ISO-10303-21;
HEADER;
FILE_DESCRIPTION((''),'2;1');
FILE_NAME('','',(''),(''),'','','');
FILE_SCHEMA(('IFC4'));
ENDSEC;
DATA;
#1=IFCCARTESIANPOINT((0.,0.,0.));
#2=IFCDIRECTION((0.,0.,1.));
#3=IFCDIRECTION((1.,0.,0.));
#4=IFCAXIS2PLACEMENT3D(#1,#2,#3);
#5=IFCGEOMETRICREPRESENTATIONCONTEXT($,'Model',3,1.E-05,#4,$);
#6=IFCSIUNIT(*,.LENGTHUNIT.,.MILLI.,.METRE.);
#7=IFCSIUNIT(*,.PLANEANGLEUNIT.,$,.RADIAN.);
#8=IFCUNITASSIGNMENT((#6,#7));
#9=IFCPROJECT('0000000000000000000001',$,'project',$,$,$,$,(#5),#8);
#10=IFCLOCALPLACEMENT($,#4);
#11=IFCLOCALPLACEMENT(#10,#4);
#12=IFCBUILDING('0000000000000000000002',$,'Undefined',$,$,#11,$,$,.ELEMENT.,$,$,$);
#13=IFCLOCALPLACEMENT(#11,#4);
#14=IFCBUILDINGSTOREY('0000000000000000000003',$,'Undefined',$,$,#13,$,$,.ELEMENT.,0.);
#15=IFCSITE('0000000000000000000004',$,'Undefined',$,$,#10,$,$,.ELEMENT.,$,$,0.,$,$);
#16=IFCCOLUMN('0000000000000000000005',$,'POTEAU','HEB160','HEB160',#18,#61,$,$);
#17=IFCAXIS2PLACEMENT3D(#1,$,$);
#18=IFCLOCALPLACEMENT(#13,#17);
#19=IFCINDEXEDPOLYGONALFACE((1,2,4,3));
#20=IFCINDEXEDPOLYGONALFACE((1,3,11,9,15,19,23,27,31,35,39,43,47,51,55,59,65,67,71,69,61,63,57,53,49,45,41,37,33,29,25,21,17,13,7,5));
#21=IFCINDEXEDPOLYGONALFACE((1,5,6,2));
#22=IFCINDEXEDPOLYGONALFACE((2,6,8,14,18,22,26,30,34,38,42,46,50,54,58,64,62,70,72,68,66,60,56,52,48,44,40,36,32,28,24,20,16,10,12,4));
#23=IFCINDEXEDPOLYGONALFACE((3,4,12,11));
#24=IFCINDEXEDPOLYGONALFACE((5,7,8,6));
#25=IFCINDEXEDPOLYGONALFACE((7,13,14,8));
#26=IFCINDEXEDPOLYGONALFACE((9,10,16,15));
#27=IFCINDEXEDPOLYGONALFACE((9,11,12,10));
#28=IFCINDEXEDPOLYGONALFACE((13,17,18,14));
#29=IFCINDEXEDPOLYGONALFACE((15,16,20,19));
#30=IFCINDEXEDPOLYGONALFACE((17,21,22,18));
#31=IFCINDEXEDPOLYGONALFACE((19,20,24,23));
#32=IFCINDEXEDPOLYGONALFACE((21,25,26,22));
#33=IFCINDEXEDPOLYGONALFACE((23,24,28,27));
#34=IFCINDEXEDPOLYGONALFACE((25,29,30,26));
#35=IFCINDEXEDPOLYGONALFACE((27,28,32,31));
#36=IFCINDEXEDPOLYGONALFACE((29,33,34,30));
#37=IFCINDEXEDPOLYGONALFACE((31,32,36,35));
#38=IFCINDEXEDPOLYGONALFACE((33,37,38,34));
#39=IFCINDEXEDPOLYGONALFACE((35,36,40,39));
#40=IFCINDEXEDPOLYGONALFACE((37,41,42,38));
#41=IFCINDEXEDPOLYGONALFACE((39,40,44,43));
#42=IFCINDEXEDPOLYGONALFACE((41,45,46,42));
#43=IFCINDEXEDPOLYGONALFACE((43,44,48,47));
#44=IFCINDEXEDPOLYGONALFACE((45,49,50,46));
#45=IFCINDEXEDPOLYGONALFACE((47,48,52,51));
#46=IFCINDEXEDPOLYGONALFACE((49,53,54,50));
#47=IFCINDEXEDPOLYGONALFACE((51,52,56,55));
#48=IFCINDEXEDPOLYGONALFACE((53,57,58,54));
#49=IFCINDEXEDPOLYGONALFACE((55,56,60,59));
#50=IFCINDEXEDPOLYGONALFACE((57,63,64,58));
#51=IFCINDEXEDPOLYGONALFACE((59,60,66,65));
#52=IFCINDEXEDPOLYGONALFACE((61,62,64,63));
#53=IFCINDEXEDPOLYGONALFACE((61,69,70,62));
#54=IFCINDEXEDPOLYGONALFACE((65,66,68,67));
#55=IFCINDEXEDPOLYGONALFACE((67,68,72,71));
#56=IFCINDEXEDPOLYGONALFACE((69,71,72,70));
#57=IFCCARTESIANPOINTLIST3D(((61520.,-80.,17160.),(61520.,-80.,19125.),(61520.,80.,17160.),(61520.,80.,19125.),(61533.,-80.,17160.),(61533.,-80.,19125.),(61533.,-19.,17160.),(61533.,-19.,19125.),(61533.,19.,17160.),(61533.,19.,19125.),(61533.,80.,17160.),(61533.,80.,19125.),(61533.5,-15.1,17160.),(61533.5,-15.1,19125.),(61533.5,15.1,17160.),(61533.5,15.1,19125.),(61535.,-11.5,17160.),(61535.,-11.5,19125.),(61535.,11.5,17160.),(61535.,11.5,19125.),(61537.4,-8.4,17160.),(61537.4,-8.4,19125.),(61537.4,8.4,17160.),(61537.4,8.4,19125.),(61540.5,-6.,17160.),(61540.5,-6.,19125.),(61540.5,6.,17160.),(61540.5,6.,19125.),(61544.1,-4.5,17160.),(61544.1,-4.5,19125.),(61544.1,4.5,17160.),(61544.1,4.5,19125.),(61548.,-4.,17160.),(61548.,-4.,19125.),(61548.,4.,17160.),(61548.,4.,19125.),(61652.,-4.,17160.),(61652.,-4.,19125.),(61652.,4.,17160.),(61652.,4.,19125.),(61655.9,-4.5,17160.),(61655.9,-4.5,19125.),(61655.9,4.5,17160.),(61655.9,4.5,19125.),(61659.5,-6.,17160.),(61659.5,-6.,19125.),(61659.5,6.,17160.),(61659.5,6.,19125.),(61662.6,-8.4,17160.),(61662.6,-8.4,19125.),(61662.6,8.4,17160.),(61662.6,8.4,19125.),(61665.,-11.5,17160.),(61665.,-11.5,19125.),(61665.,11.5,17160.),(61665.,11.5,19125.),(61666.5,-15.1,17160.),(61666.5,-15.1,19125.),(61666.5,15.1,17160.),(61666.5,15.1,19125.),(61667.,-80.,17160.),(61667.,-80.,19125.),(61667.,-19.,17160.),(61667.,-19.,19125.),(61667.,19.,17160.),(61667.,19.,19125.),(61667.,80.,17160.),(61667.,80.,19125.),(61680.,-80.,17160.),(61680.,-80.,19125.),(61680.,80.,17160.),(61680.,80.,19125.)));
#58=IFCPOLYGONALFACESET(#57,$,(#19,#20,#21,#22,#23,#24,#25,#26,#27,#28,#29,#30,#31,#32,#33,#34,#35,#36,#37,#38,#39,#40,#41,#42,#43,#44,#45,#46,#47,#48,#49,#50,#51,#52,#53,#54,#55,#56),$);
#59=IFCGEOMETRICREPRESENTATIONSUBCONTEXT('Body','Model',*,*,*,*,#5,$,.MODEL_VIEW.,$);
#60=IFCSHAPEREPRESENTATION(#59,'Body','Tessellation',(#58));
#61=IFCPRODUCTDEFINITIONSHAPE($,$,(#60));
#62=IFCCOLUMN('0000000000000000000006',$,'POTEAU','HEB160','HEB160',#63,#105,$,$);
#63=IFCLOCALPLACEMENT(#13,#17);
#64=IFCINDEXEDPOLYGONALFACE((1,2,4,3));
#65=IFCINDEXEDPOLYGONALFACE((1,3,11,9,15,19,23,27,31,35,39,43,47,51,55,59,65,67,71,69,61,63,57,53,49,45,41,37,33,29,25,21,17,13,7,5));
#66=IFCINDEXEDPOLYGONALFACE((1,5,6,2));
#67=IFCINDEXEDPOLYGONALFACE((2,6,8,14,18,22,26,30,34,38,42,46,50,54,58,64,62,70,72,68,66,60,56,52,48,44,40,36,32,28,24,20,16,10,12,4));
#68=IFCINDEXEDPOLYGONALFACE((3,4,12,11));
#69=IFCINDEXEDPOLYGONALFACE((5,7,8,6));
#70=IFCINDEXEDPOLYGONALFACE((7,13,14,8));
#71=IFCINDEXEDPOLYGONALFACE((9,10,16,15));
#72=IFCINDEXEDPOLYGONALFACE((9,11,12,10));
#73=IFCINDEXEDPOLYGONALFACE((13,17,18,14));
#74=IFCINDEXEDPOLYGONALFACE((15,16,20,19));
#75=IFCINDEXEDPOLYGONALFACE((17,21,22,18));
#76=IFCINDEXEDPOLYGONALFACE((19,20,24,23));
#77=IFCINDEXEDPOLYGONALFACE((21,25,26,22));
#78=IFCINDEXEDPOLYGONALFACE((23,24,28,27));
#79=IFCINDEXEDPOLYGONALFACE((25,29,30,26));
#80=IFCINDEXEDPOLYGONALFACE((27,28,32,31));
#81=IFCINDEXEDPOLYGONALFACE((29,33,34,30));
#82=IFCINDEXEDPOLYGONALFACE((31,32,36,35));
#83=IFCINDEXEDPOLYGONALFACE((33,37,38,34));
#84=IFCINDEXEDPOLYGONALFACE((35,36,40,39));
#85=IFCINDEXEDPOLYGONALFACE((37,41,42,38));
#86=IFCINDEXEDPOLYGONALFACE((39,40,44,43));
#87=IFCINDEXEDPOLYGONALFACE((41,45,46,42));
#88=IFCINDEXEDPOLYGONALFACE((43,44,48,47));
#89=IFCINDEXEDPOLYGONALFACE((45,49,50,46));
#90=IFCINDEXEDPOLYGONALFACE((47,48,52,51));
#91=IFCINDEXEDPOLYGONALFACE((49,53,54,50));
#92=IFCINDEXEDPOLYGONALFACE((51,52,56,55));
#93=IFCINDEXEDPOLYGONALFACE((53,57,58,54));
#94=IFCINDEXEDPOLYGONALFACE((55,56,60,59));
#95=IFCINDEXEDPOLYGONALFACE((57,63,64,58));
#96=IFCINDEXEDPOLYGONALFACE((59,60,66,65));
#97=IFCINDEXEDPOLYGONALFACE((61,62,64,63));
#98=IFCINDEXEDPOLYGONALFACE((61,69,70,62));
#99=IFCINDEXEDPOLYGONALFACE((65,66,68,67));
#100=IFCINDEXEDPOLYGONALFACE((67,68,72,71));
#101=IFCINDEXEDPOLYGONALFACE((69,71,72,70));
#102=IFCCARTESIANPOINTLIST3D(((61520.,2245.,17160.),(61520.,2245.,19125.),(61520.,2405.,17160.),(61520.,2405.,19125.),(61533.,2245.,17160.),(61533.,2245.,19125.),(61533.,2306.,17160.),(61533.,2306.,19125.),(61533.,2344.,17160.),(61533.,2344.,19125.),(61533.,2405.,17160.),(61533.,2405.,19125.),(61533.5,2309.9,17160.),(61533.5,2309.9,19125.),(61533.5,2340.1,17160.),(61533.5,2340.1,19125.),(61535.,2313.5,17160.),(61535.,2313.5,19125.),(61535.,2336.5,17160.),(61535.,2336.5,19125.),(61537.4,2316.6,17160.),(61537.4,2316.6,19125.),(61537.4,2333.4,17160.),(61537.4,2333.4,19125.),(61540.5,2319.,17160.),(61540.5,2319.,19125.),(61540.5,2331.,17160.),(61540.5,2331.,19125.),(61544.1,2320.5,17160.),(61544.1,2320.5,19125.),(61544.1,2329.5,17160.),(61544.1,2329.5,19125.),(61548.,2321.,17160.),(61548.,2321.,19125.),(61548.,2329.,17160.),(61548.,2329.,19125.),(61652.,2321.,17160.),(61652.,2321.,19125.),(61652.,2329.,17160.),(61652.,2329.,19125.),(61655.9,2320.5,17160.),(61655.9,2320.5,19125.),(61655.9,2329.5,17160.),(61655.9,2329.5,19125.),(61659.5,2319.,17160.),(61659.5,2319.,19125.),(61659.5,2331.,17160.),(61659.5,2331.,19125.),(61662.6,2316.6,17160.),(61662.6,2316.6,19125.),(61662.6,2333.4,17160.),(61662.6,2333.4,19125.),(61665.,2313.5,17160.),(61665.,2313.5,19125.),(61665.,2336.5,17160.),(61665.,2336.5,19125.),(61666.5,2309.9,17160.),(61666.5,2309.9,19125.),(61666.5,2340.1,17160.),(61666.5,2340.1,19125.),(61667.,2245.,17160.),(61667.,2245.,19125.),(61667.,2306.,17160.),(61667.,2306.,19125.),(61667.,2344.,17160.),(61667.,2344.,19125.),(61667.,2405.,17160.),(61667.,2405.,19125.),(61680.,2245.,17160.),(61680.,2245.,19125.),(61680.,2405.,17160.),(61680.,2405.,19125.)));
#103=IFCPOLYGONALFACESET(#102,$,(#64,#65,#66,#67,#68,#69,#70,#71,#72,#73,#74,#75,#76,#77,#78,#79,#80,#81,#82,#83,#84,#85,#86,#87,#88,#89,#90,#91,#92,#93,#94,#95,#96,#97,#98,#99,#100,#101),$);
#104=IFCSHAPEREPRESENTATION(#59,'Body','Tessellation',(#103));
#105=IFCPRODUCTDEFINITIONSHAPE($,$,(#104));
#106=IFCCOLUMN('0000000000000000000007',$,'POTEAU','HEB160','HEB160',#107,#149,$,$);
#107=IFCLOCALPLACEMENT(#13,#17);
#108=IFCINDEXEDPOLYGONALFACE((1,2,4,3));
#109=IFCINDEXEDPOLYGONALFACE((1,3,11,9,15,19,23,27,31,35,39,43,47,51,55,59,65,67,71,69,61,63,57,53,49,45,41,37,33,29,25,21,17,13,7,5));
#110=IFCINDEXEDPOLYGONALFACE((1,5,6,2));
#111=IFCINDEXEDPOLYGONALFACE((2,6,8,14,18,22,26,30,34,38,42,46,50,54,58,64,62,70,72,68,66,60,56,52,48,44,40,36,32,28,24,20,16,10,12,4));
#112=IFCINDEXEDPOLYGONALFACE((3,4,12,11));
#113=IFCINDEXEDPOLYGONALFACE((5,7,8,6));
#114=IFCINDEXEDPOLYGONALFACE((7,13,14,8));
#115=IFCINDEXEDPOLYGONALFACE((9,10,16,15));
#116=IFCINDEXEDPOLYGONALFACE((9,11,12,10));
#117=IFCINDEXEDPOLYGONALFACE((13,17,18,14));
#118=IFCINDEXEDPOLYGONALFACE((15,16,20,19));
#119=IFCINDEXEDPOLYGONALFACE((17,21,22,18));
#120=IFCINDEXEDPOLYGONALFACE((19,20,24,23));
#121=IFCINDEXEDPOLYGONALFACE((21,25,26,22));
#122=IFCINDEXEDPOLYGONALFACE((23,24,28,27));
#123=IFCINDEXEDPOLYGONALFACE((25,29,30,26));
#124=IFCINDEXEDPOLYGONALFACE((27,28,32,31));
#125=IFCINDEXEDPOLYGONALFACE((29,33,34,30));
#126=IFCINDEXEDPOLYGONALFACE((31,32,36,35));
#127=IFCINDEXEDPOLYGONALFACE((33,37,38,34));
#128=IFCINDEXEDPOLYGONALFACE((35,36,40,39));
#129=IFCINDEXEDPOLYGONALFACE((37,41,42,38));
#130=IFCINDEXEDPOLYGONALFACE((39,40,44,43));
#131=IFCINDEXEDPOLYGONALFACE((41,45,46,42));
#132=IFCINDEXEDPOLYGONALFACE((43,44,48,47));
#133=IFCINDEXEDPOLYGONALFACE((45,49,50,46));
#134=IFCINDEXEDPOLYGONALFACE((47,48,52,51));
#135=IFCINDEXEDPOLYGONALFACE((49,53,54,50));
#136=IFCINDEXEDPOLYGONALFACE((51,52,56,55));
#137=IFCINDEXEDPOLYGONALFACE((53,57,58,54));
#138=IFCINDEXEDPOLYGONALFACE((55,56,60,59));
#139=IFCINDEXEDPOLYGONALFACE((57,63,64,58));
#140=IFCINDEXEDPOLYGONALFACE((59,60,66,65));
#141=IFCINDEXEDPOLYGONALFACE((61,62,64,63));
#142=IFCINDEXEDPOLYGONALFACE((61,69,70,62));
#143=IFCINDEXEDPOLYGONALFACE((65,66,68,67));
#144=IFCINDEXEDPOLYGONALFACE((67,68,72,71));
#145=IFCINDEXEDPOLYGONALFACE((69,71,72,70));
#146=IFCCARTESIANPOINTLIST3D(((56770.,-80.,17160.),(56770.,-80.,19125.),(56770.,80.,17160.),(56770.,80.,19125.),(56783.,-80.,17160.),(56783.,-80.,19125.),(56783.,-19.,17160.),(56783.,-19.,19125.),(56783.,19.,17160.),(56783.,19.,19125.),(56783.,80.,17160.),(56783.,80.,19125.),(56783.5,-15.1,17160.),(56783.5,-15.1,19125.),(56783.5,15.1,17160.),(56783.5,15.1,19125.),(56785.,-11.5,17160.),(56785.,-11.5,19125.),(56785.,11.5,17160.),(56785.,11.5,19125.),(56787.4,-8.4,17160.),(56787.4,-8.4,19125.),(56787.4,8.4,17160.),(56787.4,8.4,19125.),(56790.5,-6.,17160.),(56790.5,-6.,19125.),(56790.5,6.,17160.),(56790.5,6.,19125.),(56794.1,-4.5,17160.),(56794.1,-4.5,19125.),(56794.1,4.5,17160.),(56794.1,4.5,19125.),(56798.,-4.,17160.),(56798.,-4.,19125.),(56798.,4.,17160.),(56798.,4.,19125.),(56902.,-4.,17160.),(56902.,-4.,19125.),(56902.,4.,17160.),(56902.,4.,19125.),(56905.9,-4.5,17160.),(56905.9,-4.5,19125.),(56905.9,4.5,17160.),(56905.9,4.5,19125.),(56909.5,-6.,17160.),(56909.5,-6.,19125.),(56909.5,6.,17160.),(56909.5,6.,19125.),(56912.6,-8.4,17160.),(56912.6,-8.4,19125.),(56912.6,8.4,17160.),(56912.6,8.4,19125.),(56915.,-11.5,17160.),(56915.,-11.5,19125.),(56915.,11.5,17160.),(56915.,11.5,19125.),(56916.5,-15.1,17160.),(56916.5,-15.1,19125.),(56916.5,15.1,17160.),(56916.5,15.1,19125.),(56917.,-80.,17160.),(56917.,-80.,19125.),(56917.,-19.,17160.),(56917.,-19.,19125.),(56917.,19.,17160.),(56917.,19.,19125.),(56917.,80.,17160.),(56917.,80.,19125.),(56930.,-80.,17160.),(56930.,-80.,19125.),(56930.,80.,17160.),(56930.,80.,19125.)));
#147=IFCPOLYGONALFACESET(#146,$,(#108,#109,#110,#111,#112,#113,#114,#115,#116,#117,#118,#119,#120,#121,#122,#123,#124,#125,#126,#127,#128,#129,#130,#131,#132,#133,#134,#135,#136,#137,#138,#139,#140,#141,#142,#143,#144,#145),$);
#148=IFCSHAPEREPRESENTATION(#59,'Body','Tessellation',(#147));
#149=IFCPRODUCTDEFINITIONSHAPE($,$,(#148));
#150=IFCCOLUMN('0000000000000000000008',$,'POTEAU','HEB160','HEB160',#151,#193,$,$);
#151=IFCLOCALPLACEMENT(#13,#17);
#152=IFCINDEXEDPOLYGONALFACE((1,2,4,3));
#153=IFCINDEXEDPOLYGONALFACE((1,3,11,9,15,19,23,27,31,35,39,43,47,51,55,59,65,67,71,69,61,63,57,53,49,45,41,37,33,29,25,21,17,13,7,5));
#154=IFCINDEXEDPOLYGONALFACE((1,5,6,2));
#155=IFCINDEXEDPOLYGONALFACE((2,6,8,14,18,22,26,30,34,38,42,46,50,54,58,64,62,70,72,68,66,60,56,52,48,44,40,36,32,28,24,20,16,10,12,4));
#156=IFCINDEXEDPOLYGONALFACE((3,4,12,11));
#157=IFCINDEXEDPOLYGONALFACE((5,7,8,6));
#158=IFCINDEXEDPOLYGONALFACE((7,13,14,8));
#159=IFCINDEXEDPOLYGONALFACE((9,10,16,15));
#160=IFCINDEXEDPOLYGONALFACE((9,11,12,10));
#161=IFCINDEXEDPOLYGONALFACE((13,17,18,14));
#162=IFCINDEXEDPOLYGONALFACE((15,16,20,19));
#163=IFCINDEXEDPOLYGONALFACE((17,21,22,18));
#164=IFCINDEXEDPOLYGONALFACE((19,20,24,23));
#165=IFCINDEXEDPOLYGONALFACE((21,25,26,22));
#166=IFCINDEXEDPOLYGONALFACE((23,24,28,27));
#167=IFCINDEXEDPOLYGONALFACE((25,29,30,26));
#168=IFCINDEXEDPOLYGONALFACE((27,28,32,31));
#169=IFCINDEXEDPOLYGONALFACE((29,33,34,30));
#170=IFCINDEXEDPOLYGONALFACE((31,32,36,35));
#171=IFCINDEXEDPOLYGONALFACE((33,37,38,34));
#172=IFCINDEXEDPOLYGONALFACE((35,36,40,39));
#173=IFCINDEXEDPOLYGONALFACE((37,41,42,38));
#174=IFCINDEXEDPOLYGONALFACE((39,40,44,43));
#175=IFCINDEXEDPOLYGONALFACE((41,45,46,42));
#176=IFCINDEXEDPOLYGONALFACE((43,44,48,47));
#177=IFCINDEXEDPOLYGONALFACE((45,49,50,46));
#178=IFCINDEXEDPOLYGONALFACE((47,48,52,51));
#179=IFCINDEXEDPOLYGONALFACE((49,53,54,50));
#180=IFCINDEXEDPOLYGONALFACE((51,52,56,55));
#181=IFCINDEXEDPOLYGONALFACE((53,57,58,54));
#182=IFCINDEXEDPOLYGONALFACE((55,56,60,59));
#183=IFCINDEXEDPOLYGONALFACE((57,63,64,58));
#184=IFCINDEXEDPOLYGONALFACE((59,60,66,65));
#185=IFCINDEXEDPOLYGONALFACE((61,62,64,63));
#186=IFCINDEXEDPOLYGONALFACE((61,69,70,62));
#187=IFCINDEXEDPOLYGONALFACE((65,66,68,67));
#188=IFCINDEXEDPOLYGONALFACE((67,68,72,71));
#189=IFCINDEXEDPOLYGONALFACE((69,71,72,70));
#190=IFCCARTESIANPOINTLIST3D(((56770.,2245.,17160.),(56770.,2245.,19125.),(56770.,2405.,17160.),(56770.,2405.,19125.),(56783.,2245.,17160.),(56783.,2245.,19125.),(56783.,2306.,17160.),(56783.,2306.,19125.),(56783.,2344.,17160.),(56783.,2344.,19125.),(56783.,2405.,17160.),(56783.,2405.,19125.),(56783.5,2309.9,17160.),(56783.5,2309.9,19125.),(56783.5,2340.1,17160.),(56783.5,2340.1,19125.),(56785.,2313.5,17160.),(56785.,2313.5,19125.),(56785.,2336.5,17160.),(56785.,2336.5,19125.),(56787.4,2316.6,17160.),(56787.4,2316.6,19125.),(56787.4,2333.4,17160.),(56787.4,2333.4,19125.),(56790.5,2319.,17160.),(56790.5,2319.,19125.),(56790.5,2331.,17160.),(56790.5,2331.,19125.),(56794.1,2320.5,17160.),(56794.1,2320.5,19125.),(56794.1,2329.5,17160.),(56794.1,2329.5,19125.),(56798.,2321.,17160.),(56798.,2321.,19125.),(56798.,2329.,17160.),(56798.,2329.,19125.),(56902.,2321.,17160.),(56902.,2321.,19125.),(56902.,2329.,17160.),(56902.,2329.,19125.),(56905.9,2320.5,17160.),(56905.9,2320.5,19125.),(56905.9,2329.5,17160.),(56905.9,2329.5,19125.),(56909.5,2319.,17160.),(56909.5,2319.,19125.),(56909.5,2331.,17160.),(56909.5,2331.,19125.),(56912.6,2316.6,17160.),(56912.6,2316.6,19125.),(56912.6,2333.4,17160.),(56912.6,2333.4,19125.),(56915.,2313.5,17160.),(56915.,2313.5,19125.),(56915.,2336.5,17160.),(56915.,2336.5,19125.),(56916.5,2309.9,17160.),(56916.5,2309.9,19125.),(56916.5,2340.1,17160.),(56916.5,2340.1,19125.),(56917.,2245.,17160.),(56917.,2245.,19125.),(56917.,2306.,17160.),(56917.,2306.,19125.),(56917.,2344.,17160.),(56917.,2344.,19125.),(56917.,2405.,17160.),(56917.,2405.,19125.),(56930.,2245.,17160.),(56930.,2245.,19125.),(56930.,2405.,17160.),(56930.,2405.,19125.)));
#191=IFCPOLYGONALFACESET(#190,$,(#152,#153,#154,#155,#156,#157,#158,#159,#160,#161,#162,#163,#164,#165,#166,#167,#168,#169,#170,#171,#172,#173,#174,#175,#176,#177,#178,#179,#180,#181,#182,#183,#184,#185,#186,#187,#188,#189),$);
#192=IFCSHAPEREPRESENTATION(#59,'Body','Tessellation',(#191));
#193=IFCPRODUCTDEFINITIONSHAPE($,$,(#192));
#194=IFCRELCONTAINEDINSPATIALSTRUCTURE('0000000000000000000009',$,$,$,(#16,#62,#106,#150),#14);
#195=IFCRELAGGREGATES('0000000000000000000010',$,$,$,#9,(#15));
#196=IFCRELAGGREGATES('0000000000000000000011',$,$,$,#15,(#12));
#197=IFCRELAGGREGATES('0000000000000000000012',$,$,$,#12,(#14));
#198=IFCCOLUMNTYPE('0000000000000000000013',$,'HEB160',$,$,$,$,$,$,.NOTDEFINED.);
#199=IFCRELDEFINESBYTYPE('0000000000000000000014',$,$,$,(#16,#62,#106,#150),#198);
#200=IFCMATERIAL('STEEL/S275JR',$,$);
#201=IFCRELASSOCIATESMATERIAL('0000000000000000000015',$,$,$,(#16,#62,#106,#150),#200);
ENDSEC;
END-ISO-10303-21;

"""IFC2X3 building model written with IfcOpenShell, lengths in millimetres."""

from ifc_helpers import new_model, si_unit, frame, origin_with_axes, origin_2d_with_axis, place, context, subcontext, project, spatial, i_section, extrude, material, type_object, element, save


model = new_model("IFC2X3")

# Units and contexts
model_context = context("Model", 3, precision=1e-05, world=origin_with_axes())
body_context = subcontext(model_context, "Body", "Model", "MODEL_VIEW")
ifc_project = project(units=[si_unit("LENGTHUNIT", "METRE", prefix="MILLI"), si_unit("PLANEANGLEUNIT", "RADIAN")], contexts=[model_context])

# Site, building, storey
site_placement = place(None, origin_with_axes())
site = spatial("IfcSite", under=ifc_project, at=site_placement, Name="Undefined", CompositionType="ELEMENT", RefElevation=0.0)
building_placement = place(site_placement, origin_with_axes())
building = spatial("IfcBuilding", under=site, at=building_placement, Name="Undefined", CompositionType="ELEMENT")
storey_placement = place(building_placement, origin_with_axes())
storey = spatial("IfcBuildingStorey", under=building, at=storey_placement, Name="Undefined", CompositionType="ELEMENT", Elevation=0.0)

# Columns
ifc_material_1 = material(Name="STEEL/S275JR")
column_type_1 = type_object("IfcColumnType", Name="HEB160", PredefinedType="NOTDEFINED")
for number, where, z_axis, x_axis, name in (
    (1, (61600.0, 0.0, 17160.0), (0.0, 0.0, 1.0), (1.0, 0.0, 0.0), "POTEAU"),
    (2, (61600.0, 2325.0, 17160.0), (0.0, 0.0, 1.0), (1.0, 0.0, 0.0), "POTEAU"),
    (3, (56850.0, 0.0, 17160.0), (0.0, 0.0, 1.0), (1.0, 0.0, 0.0), "POTEAU"),
    (4, (56850.0, 2325.0, 17160.0), (0.0, 0.0, 1.0), (1.0, 0.0, 0.0), "POTEAU"),
):
    element("IfcColumn", number, at=place(storey_placement, frame(where, z_axis=z_axis, x_axis=x_axis)), inside=storey, type_object=column_type_1, material=ifc_material_1, Name=name, Description="HEB160", ObjectType="HEB160", context=body_context, shape_type="SweptSolid", body=[
        extrude(i_section(OverallWidth=160.0, OverallDepth=160.0, WebThickness=8.0, FlangeThickness=13.0, FilletRadius=15.0, at=origin_2d_with_axis()), frame((0.0, 0.0, 1965.0), z_axis=(0.0, 0.0, -1.0), x_axis=(0.0, -1.0, 0.0)), (0.0, 0.0, 1.0), 1965.0),
    ])

save(model, "model.ifc")
